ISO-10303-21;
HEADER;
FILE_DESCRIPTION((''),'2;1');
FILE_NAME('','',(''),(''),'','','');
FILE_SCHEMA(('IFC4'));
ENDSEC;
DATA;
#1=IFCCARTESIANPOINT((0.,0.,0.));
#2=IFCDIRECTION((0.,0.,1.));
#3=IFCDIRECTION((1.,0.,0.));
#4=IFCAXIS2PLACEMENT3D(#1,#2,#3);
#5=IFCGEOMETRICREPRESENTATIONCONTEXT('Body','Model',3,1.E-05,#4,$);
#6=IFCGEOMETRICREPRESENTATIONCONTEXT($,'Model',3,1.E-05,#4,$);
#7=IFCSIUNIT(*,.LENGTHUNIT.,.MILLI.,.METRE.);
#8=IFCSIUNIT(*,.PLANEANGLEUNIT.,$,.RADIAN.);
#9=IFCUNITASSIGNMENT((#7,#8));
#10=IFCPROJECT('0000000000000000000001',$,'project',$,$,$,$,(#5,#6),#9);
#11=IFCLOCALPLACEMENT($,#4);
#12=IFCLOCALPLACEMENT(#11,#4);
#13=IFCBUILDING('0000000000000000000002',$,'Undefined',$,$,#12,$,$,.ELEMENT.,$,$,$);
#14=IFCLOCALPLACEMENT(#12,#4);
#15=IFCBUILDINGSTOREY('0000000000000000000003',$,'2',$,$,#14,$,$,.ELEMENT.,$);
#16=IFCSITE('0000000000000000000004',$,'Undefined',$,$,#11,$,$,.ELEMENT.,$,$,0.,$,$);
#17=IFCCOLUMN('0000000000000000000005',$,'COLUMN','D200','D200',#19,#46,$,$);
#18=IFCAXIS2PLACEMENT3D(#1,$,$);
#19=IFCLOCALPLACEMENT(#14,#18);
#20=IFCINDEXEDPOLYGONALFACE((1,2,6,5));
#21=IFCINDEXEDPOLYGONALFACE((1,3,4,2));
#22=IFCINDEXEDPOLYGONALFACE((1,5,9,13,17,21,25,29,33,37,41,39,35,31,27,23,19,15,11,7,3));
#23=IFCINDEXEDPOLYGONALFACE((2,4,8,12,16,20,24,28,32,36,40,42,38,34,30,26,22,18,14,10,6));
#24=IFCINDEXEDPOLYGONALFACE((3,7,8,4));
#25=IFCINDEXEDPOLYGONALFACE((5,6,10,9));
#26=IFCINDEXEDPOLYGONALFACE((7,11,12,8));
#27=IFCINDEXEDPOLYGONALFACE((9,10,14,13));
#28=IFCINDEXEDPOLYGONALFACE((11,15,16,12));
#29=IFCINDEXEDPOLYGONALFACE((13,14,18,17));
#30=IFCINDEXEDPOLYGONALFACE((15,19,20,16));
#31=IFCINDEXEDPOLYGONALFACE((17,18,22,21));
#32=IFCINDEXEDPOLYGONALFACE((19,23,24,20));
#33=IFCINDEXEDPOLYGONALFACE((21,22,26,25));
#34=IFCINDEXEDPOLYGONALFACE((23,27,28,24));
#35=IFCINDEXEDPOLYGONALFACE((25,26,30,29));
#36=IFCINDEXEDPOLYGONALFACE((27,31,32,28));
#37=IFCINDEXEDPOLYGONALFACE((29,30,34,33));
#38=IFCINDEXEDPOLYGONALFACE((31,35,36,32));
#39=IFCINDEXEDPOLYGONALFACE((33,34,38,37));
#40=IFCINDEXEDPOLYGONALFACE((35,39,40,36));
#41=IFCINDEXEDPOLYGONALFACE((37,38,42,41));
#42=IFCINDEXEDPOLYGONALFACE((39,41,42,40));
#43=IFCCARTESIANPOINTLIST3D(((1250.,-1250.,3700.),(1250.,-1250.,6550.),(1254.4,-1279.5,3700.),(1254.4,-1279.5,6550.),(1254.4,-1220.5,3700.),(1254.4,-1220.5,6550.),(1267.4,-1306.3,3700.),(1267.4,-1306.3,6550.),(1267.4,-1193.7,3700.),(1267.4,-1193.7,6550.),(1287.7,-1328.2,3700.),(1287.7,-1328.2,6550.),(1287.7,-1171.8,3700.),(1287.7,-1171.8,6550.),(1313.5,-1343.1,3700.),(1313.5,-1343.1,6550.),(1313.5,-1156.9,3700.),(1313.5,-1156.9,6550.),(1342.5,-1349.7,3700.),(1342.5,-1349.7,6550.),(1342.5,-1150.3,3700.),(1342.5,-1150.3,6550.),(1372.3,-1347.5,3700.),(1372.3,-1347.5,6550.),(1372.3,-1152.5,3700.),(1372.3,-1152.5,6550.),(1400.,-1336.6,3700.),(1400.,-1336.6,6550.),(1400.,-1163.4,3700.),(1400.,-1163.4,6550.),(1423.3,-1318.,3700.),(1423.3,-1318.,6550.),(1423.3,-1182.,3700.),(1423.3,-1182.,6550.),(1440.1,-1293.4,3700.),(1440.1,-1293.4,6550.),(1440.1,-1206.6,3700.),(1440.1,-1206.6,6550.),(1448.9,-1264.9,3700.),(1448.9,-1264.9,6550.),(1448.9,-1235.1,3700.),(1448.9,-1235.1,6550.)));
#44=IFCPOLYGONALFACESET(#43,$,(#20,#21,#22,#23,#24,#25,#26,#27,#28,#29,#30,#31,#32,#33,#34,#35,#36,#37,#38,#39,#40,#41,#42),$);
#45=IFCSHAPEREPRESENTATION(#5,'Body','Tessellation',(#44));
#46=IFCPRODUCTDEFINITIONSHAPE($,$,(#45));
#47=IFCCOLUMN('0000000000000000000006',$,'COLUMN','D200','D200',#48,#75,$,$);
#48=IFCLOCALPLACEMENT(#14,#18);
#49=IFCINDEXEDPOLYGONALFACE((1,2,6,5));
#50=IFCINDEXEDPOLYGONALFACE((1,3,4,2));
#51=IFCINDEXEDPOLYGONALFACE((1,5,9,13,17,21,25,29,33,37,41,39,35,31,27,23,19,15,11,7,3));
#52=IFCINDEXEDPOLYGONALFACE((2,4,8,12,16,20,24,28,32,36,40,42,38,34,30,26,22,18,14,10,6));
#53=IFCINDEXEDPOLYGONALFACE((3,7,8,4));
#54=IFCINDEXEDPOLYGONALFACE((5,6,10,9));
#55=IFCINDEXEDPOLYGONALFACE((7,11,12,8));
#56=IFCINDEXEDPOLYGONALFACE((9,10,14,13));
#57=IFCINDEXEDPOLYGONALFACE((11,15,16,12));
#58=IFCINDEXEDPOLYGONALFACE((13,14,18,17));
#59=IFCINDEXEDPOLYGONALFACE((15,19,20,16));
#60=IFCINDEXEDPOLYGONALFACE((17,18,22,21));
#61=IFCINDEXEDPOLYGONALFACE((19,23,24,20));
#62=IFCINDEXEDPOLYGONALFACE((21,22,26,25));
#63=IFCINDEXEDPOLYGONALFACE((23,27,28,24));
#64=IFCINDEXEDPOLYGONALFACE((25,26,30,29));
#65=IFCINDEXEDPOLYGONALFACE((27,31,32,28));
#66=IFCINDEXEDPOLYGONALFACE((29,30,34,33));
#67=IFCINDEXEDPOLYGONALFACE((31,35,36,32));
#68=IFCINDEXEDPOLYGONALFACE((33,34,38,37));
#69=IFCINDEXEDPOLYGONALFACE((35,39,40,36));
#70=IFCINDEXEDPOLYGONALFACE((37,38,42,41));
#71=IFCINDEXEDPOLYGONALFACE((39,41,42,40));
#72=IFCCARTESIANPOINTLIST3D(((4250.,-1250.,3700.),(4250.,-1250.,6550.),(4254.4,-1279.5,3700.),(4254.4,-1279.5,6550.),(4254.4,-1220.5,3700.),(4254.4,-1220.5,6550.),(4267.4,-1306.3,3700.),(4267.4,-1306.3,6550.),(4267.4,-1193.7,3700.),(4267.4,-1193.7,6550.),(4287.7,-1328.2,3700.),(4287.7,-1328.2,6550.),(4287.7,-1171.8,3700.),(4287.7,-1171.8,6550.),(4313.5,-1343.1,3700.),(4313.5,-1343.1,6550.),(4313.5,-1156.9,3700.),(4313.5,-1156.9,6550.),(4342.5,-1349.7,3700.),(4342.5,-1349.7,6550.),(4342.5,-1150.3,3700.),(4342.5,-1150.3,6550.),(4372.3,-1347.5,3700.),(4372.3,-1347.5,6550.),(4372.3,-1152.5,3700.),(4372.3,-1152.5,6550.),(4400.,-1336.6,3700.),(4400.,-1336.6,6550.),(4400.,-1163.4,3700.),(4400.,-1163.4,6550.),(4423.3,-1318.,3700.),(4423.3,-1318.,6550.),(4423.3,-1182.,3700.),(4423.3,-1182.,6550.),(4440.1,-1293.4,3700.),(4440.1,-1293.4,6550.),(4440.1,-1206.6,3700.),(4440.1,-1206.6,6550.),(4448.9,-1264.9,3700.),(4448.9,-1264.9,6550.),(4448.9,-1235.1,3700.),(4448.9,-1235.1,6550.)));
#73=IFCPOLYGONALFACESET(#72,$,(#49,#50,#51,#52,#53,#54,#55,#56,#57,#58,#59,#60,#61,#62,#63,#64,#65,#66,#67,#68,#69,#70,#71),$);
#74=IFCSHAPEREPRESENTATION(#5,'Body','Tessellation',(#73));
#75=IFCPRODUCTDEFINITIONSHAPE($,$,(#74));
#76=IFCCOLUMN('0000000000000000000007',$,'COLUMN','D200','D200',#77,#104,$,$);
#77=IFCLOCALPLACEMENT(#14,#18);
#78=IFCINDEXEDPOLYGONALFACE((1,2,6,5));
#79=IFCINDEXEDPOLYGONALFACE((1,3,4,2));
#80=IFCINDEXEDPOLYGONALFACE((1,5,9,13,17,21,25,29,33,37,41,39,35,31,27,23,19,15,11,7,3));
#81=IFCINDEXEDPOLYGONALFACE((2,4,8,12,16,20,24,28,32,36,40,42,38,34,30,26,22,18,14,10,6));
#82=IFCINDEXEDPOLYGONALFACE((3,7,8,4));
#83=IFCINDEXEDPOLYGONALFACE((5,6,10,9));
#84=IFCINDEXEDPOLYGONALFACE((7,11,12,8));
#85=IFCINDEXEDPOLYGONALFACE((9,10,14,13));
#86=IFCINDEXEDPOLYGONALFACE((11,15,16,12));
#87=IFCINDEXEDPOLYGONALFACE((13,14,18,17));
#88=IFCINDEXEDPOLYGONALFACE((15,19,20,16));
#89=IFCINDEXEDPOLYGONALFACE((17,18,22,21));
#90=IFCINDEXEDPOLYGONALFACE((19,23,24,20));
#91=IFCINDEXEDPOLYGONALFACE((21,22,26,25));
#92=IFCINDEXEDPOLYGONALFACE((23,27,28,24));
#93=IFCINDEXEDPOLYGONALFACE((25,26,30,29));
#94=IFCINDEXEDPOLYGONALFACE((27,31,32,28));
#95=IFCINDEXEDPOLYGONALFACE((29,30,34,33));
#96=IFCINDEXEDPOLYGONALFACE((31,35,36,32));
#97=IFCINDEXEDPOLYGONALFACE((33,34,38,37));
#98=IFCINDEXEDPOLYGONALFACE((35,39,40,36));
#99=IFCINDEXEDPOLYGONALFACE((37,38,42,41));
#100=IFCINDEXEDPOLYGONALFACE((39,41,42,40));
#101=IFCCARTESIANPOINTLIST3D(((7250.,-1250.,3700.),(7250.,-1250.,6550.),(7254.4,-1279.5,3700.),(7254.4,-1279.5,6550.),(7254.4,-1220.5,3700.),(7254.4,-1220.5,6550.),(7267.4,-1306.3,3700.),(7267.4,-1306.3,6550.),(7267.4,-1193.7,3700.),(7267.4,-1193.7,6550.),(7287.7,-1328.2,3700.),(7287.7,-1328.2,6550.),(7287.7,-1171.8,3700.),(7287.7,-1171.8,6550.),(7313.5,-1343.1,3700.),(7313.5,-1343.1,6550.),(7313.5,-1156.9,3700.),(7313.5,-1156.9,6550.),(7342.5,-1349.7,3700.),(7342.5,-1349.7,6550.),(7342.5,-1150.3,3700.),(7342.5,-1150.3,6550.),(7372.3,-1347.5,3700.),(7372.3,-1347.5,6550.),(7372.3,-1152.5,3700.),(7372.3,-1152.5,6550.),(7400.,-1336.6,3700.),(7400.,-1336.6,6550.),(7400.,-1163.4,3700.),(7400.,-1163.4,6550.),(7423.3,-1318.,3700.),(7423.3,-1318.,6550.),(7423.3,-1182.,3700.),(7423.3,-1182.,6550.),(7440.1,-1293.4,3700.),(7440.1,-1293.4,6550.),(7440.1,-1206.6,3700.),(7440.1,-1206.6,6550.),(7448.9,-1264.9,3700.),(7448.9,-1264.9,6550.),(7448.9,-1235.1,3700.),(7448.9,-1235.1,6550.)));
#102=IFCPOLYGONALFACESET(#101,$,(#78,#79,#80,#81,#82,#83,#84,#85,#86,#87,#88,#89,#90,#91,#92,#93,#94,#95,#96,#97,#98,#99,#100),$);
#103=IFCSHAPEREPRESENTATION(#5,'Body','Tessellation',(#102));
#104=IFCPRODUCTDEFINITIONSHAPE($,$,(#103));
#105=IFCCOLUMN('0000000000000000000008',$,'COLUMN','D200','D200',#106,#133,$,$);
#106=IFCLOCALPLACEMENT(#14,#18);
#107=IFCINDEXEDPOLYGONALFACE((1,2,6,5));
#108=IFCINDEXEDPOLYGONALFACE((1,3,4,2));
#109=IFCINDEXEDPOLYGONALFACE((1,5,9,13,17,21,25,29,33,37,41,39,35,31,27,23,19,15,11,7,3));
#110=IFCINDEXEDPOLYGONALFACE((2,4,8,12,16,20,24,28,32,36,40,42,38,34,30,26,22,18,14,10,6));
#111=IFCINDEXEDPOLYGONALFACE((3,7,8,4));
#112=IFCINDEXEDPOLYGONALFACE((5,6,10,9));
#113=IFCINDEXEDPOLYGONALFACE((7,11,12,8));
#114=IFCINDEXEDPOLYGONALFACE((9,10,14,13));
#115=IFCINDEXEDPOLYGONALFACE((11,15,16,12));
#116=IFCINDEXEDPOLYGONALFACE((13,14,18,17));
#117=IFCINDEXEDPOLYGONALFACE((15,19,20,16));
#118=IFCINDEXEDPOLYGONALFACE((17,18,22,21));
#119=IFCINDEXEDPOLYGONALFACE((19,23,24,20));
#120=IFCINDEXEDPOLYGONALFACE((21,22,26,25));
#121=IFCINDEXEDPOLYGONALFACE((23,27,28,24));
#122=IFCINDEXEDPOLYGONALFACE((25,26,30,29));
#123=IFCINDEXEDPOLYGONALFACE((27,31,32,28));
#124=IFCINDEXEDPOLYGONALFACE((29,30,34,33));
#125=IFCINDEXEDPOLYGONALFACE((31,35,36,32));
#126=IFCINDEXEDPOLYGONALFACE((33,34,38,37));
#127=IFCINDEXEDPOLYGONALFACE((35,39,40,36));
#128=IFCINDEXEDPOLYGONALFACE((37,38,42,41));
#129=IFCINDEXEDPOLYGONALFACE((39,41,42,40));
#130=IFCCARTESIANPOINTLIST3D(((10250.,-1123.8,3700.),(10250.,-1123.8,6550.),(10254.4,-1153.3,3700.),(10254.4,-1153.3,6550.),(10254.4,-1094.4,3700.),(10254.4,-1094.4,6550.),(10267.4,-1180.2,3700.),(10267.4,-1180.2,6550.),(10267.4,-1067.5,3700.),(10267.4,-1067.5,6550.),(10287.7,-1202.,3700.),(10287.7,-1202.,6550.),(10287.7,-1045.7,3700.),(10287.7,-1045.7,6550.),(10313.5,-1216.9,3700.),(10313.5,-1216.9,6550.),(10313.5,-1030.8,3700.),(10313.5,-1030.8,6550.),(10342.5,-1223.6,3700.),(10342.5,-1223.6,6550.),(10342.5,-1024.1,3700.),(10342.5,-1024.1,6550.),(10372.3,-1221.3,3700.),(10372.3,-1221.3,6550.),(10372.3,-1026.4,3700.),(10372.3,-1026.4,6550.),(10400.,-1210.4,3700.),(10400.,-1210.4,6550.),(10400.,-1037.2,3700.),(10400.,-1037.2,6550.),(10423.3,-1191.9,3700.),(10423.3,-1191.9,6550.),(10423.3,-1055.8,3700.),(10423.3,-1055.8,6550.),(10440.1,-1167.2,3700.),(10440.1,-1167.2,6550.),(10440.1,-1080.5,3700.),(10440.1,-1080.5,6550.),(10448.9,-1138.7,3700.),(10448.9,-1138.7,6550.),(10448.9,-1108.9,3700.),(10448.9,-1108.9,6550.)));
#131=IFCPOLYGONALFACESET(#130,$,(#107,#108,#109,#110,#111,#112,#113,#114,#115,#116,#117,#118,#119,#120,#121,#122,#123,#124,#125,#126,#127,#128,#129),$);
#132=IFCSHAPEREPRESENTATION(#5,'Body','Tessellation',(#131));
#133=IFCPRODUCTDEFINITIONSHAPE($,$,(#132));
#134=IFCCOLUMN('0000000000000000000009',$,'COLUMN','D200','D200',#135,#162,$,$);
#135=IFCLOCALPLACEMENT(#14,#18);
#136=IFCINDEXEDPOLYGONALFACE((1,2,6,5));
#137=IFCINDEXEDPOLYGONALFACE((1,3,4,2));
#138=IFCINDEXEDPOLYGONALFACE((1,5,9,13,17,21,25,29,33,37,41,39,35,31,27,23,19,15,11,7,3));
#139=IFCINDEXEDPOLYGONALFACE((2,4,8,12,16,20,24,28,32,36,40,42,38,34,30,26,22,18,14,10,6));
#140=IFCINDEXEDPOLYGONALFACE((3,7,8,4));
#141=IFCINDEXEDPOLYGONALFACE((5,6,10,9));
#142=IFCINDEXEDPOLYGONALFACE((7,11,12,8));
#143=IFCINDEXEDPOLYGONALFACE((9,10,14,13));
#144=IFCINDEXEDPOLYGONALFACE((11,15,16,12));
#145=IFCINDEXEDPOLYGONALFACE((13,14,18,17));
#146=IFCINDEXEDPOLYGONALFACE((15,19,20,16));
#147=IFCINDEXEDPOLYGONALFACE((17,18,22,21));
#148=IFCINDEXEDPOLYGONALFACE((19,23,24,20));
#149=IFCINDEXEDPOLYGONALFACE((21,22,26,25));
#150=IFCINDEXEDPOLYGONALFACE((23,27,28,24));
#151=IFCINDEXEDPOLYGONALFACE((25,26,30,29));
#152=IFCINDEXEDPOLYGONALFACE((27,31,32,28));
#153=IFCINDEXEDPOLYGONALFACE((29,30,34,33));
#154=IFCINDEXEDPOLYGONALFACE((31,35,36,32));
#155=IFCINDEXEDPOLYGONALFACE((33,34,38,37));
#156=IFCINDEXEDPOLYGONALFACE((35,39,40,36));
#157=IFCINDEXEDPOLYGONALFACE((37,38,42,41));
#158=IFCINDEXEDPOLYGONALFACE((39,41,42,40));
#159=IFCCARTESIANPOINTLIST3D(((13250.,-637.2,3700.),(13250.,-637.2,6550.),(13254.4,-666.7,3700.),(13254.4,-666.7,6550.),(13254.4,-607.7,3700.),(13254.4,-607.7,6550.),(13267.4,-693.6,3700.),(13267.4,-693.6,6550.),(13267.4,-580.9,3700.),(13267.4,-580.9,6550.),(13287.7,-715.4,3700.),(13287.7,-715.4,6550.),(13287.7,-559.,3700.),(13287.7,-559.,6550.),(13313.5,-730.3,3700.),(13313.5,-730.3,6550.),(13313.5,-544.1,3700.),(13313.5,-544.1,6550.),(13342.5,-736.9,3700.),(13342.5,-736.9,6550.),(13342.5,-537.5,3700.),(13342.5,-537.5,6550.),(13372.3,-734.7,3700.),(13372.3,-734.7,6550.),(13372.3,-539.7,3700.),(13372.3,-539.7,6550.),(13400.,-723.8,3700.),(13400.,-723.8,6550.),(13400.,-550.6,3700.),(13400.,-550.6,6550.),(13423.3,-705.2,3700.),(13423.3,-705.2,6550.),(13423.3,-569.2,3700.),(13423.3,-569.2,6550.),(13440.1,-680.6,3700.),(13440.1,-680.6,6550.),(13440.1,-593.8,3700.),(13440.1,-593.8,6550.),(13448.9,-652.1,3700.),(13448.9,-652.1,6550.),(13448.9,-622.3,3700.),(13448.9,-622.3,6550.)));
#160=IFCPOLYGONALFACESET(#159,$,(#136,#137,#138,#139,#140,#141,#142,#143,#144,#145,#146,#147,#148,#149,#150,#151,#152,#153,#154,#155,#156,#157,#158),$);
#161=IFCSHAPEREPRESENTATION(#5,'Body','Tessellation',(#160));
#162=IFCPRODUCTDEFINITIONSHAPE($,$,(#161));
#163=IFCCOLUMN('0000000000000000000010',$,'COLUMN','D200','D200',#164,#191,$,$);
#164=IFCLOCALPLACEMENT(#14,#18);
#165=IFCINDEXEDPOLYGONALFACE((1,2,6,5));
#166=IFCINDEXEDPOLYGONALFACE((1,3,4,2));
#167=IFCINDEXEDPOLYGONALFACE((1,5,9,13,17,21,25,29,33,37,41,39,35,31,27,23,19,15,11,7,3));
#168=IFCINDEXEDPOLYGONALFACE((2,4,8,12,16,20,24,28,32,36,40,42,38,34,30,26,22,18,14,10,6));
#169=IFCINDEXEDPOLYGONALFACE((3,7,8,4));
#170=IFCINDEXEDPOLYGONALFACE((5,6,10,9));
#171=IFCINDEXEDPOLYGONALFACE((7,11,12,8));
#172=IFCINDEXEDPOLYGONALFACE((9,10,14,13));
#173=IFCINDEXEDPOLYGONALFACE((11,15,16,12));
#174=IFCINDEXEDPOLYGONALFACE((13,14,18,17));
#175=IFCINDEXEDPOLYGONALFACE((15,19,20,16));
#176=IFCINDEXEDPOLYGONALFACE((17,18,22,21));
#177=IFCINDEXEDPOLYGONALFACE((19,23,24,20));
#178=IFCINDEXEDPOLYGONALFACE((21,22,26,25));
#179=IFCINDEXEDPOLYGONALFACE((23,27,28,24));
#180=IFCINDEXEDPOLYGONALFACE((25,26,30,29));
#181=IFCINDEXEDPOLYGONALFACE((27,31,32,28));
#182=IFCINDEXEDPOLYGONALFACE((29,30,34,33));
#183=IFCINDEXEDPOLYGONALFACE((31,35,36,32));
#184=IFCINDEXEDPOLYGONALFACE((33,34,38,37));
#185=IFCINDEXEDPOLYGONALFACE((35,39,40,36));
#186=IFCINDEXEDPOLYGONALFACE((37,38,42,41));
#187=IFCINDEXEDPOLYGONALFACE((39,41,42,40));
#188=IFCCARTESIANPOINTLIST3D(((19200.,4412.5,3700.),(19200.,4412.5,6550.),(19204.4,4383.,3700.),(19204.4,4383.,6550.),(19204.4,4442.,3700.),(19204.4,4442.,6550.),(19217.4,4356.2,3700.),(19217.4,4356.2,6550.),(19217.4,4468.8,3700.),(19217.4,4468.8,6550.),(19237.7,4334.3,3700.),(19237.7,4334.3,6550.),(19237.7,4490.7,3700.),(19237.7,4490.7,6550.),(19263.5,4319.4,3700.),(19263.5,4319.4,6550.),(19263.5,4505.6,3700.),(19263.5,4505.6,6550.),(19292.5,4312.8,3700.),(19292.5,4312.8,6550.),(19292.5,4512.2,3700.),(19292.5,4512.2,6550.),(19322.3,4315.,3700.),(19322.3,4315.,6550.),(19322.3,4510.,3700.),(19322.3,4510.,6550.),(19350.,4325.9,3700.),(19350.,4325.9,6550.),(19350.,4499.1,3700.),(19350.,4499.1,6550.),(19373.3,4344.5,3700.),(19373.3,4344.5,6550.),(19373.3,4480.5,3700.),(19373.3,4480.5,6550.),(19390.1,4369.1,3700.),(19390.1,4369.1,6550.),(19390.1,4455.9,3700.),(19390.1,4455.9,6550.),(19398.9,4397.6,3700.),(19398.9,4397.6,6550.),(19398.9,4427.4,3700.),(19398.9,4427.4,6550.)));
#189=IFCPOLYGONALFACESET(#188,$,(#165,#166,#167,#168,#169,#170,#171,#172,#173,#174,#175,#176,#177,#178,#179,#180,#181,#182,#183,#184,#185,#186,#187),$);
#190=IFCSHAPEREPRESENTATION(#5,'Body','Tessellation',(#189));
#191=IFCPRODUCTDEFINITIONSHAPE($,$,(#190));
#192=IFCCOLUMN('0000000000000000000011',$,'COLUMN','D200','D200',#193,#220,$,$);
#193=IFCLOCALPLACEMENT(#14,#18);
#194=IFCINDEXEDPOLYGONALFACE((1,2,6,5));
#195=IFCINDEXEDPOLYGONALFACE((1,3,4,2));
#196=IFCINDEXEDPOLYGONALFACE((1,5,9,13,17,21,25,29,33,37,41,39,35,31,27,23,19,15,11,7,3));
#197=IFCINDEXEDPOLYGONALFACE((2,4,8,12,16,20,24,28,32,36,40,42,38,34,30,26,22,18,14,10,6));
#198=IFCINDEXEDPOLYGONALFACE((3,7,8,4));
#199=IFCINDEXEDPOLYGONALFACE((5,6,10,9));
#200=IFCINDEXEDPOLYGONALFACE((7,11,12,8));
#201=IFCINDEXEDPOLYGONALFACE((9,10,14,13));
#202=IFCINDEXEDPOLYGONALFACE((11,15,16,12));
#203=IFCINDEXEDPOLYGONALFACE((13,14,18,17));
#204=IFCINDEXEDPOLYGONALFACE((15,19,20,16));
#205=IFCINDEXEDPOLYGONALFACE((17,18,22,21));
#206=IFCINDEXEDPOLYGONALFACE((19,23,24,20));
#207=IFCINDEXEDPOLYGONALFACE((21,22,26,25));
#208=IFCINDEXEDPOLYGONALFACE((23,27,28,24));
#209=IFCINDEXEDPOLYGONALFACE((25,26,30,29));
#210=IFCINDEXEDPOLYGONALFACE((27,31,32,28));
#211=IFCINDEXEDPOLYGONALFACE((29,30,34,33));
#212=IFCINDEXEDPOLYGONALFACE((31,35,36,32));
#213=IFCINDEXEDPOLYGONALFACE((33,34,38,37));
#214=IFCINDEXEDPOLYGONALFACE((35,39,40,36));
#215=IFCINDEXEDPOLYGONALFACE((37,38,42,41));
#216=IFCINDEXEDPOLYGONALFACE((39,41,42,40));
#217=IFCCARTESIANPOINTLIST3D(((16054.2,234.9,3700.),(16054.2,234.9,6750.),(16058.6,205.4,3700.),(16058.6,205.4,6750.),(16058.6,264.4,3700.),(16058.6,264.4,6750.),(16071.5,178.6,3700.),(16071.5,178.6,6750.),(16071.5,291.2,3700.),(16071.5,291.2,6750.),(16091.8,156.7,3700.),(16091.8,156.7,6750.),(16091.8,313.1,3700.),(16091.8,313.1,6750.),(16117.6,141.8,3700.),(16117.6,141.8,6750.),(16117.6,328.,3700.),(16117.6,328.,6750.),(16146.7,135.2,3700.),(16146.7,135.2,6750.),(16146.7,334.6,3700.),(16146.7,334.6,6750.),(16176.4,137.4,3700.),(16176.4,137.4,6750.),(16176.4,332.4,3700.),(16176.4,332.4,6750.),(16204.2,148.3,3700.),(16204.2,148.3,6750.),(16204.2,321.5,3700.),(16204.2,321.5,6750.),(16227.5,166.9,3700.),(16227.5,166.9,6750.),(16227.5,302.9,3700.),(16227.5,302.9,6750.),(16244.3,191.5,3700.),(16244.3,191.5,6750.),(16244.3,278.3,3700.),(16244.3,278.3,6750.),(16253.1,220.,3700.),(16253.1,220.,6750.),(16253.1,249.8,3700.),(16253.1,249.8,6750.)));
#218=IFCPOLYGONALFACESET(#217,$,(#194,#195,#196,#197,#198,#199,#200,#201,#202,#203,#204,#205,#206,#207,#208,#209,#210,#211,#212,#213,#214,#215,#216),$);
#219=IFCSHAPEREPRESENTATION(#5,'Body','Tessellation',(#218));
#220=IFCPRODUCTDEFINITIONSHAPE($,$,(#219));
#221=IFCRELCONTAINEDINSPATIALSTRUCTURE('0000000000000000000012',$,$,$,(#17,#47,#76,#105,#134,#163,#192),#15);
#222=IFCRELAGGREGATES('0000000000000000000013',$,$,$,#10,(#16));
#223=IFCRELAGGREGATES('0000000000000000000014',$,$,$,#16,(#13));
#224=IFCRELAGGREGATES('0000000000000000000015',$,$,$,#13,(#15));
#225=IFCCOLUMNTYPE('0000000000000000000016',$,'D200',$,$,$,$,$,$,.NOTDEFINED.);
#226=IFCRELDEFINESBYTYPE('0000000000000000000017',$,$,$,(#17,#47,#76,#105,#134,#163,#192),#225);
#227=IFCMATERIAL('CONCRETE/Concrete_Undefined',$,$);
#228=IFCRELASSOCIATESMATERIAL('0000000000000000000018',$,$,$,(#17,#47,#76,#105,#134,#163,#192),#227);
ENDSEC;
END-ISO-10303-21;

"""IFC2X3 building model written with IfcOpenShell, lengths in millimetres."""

from ifc_helpers import new_model, si_unit, frame, origin_with_axes, origin_2d_with_axis, place, context, project, spatial, circle, extrude, material, type_object, element, save


model = new_model("IFC2X3")

# Units and contexts
model_context_1 = context("Model", 3, precision=1e-05, world=origin_with_axes(), identifier="Body")
model_context_2 = context("Model", 3, precision=1e-05, world=origin_with_axes())
ifc_project = project(units=[si_unit("LENGTHUNIT", "METRE", prefix="MILLI"), si_unit("PLANEANGLEUNIT", "RADIAN")], contexts=[model_context_1, model_context_2])

# Site, building, storey
site_placement = place(None, origin_with_axes())
site = spatial("IfcSite", under=ifc_project, at=site_placement, Name="Undefined", CompositionType="ELEMENT", RefElevation=0.0)
building_placement = place(site_placement, origin_with_axes())
building = spatial("IfcBuilding", under=site, at=building_placement, Name="Undefined", CompositionType="ELEMENT")
storey_placement = place(building_placement, origin_with_axes())
storey = spatial("IfcBuildingStorey", under=building, at=storey_placement, Name="2", CompositionType="ELEMENT")

# Columns
ifc_material = material(Name="CONCRETE/Concrete_Undefined")
column_type = type_object("IfcColumnType", Name="D200", PredefinedType="NOTDEFINED")
for number, where, z_axis, x_axis, name in (
    (1, (1350.0, -1250.0, 3700.0), (0.0, 0.0, 1.0), (1.0, 0.0, 0.0), "COLUMN"),
    (2, (4350.0, -1250.0, 3700.0), (0.0, 0.0, 1.0), (1.0, 0.0, 0.0), "COLUMN"),
    (3, (7350.0, -1250.0, 3700.0), (0.0, 0.0, 1.0), (1.0, 0.0, 0.0), "COLUMN"),
    (4, (10350.0, -1123.8, 3700.0), (0.0, 0.0, 1.0), (1.0, 0.0, 0.0), "COLUMN"),
    (5, (13350.0, -637.2, 3700.0), (0.0, 0.0, 1.0), (1.0, 0.0, 0.0), "COLUMN"),
    (6, (19300.0, 4412.5, 3700.0), (0.0, 0.0, 1.0), (1.0, 0.0, 0.0), "COLUMN"),
):
    element("IfcColumn", number, at=place(storey_placement, frame(where, z_axis=z_axis, x_axis=x_axis)), inside=storey, type_object=column_type, material=ifc_material, Name=name, Description="D200", ObjectType="D200", context=model_context_1, shape_type="SweptSolid", body=[
        extrude(circle(Radius=100.0, at=origin_2d_with_axis()), frame((0.0, 0.0, 2850.0), z_axis=(0.0, 0.0, -1.0), x_axis=(-1.0, 0.0, 0.0)), (0.0, 0.0, 1.0), 2850.0),
    ])
for number, where, z_axis, x_axis, name in (
    (7, (16154.2, 234.9, 3700.0), (0.0, 0.0, 1.0), (1.0, 0.0, 0.0), "COLUMN"),
):
    element("IfcColumn", number, at=place(storey_placement, frame(where, z_axis=z_axis, x_axis=x_axis)), inside=storey, type_object=column_type, material=ifc_material, Name=name, Description="D200", ObjectType="D200", context=model_context_1, shape_type="SweptSolid", body=[
        extrude(circle(Radius=100.0, at=origin_2d_with_axis()), frame((0.0, 0.0, 3050.0), z_axis=(0.0, 0.0, -1.0), x_axis=(-1.0, 0.0, 0.0)), (0.0, 0.0, 1.0), 3050.0),
    ])

save(model, "model.ifc")
